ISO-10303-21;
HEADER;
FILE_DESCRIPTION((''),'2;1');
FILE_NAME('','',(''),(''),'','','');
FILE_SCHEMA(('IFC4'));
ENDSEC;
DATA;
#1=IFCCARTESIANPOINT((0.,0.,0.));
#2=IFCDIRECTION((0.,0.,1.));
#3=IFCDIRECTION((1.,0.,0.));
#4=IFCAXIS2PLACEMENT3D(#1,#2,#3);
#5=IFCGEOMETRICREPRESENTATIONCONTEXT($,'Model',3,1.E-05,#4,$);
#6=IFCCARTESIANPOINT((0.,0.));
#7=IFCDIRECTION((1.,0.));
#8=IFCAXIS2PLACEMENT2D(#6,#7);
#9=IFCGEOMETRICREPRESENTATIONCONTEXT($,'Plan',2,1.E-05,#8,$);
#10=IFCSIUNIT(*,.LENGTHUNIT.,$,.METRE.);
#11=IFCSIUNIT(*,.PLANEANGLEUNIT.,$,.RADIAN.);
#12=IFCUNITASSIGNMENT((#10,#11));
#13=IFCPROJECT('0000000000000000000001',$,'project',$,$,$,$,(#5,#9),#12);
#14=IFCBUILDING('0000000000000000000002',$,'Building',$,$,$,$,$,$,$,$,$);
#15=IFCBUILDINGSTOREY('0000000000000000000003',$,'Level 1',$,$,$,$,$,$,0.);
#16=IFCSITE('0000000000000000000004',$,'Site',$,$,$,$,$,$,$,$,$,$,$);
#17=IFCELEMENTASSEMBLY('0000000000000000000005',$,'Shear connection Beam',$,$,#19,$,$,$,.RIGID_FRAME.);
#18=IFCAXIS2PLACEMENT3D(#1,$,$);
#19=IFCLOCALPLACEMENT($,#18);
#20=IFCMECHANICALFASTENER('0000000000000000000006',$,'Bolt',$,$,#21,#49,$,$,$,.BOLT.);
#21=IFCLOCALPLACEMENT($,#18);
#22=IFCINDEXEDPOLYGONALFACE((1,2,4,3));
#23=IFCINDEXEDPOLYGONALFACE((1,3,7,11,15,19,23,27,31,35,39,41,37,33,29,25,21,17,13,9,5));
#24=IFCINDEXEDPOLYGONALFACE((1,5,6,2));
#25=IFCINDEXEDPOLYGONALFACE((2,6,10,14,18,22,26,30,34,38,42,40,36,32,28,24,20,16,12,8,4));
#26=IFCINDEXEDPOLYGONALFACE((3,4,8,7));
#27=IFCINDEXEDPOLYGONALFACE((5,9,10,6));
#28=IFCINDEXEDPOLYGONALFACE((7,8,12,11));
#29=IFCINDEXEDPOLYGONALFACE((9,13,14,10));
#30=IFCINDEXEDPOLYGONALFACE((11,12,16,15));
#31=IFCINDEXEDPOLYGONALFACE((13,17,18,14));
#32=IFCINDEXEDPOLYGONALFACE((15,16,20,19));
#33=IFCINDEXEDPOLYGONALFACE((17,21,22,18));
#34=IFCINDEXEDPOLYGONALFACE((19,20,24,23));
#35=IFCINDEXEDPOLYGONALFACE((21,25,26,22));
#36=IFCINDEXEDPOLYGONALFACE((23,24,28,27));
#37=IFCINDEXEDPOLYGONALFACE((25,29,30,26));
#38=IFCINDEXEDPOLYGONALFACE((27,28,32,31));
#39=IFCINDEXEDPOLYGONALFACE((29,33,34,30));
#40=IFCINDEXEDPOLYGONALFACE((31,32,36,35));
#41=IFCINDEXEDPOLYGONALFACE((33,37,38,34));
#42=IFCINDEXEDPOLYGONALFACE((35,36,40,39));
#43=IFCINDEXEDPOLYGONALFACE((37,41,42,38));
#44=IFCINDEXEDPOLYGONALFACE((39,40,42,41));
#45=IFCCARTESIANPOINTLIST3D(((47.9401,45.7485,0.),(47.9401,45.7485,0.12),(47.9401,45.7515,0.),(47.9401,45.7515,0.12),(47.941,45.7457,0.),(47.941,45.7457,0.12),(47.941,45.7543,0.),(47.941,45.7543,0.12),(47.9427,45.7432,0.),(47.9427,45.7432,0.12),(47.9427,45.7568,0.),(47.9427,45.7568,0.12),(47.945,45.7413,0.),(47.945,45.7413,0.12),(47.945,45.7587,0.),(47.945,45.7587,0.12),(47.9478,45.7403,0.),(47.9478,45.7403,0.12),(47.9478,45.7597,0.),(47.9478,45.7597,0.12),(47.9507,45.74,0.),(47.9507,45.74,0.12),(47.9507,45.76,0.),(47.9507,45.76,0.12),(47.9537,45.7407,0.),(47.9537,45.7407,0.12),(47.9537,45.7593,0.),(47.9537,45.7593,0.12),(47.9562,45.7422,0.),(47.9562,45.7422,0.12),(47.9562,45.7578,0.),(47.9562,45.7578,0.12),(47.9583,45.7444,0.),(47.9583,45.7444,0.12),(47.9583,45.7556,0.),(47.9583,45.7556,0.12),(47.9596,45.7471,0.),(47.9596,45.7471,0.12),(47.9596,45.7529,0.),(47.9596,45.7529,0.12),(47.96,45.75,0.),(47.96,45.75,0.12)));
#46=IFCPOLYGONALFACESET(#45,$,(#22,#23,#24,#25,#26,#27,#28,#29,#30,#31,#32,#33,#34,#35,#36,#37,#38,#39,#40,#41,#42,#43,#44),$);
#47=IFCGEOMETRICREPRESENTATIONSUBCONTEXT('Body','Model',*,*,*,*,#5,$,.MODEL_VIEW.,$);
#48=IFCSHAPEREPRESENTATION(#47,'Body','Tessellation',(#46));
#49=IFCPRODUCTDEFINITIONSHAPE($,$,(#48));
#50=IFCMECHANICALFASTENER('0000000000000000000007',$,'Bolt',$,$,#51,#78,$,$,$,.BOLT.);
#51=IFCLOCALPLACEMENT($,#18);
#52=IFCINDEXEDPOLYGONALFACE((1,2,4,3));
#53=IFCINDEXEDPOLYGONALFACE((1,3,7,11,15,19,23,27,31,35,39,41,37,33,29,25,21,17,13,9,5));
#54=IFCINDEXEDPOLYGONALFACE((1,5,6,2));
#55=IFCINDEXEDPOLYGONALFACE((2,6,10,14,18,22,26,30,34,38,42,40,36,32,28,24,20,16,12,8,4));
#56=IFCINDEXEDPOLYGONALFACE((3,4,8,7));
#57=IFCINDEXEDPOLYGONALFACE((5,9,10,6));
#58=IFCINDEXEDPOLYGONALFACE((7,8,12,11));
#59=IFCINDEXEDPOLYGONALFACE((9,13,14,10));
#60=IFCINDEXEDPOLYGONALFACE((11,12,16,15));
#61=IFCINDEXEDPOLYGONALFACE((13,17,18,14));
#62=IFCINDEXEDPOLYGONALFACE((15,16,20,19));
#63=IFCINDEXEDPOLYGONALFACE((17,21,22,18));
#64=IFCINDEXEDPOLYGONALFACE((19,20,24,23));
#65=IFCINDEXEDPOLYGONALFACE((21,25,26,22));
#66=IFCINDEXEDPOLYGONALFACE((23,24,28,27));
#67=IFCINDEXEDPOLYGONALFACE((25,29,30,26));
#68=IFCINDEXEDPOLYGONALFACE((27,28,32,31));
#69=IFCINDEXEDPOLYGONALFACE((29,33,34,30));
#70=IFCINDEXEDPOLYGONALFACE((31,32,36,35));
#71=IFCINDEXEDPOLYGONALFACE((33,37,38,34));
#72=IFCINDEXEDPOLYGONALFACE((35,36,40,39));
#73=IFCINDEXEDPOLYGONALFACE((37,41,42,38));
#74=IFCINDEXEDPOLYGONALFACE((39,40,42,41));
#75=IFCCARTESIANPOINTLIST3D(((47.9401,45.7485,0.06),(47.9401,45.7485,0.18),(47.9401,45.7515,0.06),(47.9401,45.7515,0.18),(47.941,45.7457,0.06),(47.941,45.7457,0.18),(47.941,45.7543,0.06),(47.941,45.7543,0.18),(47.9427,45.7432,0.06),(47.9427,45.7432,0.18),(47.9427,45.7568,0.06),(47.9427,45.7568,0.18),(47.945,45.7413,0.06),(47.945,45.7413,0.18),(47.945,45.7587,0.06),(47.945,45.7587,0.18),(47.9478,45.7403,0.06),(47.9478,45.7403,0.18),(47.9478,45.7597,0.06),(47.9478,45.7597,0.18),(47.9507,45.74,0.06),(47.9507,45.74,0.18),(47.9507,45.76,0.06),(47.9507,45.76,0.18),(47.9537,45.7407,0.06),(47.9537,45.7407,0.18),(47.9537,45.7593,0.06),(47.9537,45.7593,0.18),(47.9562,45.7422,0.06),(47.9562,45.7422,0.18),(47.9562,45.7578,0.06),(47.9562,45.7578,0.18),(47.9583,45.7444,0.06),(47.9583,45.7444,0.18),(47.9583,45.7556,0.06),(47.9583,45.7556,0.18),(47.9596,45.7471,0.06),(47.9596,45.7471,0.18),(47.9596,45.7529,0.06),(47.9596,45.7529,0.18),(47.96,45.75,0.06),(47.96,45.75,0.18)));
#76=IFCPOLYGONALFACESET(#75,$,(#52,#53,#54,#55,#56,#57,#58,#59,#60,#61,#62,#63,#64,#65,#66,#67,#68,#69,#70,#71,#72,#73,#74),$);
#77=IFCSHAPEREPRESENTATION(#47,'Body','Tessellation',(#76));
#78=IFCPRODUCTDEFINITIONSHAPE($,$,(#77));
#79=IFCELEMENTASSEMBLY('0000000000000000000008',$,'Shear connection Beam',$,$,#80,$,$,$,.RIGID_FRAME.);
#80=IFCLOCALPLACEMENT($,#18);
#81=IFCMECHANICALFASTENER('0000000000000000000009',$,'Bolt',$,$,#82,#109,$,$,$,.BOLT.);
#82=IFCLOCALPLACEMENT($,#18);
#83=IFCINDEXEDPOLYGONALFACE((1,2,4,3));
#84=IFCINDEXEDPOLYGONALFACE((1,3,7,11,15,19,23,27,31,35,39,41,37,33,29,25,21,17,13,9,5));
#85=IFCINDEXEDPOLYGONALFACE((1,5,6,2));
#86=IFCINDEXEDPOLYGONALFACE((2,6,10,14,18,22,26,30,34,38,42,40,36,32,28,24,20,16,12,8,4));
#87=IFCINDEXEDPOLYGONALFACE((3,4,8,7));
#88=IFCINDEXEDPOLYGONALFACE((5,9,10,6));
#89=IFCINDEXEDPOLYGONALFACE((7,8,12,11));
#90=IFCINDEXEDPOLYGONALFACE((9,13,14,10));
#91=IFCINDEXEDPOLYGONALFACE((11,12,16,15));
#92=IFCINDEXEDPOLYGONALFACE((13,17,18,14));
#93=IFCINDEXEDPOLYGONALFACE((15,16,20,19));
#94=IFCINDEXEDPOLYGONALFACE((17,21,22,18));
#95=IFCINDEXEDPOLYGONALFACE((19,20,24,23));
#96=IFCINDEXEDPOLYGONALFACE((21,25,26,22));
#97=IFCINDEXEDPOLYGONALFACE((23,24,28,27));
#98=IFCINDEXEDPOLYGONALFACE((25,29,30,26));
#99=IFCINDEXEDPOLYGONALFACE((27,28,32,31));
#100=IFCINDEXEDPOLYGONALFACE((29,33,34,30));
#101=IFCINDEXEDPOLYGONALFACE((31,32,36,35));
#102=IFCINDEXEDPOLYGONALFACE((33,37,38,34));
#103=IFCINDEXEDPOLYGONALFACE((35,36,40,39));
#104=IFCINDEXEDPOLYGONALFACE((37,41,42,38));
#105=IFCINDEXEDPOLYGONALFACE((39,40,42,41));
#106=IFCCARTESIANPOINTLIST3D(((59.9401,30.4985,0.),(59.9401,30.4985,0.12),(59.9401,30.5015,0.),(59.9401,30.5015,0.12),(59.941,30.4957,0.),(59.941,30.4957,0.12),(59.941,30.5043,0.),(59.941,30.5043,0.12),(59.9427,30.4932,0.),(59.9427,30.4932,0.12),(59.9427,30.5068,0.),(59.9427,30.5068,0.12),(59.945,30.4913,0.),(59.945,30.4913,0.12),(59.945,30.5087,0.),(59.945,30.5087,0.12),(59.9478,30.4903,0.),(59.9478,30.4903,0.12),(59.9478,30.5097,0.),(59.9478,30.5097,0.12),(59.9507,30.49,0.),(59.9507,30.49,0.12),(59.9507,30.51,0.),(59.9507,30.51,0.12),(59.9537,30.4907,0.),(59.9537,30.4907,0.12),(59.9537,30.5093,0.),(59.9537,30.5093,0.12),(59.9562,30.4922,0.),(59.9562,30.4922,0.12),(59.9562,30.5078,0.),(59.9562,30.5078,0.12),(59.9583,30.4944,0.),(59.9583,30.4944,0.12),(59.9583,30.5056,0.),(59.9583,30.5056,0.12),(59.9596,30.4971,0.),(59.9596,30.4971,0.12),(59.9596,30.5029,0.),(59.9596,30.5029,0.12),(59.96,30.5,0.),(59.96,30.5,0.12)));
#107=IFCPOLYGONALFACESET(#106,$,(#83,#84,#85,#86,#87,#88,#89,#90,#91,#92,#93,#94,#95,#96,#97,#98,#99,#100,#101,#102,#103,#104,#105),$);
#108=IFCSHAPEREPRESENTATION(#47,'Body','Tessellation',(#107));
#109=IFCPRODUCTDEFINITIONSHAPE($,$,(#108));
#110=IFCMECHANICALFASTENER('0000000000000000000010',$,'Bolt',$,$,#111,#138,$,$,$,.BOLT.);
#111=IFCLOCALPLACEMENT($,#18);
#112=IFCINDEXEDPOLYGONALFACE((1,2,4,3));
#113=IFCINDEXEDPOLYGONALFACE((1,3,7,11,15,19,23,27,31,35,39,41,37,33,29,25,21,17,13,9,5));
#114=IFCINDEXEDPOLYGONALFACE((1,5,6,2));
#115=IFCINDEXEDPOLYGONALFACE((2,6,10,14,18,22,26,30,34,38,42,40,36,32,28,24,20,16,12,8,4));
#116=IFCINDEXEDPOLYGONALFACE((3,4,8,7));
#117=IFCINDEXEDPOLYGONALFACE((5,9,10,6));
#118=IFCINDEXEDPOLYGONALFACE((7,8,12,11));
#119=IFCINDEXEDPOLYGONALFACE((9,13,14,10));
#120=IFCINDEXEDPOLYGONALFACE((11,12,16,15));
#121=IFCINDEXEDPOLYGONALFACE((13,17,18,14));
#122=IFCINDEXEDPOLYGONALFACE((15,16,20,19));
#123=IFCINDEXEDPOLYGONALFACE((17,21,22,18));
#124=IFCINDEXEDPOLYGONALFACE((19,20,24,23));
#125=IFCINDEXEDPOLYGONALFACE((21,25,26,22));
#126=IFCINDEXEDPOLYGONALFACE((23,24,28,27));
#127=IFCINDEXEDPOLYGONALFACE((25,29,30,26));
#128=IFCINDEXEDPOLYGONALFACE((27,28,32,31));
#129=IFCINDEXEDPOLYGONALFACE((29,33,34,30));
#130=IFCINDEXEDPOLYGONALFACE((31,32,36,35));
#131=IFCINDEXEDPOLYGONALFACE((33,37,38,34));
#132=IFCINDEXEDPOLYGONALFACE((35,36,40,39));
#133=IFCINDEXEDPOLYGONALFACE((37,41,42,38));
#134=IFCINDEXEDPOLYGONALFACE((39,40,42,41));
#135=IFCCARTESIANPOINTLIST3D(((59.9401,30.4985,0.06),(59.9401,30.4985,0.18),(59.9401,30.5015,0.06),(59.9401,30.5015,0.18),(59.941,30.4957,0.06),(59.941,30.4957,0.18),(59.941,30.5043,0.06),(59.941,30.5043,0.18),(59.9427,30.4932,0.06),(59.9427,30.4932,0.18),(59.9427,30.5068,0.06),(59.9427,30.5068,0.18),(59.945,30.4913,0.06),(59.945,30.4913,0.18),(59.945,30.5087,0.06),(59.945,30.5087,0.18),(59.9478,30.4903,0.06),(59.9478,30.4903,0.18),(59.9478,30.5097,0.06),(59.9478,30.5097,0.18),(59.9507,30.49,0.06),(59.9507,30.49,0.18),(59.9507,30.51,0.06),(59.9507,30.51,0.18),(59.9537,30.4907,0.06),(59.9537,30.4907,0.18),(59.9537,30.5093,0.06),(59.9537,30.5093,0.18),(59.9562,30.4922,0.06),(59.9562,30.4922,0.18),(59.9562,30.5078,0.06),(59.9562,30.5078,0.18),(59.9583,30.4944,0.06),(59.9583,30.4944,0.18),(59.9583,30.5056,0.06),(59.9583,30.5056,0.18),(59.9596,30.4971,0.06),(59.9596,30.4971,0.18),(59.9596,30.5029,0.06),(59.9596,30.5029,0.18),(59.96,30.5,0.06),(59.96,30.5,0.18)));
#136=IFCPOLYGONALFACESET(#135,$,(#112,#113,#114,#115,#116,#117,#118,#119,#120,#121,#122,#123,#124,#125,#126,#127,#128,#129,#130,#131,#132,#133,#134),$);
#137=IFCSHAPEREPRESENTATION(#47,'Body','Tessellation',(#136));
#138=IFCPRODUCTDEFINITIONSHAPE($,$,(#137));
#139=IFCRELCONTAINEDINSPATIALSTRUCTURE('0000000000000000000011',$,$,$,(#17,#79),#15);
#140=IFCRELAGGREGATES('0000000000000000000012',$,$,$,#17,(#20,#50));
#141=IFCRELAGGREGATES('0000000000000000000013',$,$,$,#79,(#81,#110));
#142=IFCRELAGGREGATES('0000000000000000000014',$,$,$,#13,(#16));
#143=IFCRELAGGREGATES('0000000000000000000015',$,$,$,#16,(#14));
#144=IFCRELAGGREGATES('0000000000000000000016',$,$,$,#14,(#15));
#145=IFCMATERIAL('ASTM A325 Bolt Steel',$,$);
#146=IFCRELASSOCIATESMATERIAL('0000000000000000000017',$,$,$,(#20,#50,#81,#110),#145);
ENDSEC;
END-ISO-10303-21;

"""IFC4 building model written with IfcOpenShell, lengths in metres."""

from ifc_helpers import new_model, si_unit, frame, origin_with_axes, origin_2d, origin_2d_with_axis, place, context, subcontext, project, spatial, circle, extrude, material, element, aggregate, save


model = new_model("IFC4")

# Units and contexts
model_context = context("Model", 3, precision=1e-05, world=origin_with_axes())
plan_context = context("Plan", 2, precision=1e-05, world=origin_2d_with_axis())
body_context = subcontext(model_context, "Body", "Model", "MODEL_VIEW")
ifc_project = project(units=[si_unit("LENGTHUNIT", "METRE"), si_unit("PLANEANGLEUNIT", "RADIAN")], contexts=[model_context, plan_context])

# Site, building, storey
site = spatial("IfcSite", under=ifc_project, Name="Site")
building = spatial("IfcBuilding", under=site, Name="Building")
storey = spatial("IfcBuildingStorey", under=building, Name="Level 1", Elevation=0.0)

# Element assembly
assembly_1 = element("IfcElementAssembly", 1, inside=storey, Name="Shear connection Beam", PredefinedType="RIGID_FRAME")

# Shared definitions
ifc_material_1 = material(Name="ASTM A325 Bolt Steel")

# Mechanical fasteners
mechanical_fastener_1_placement = place(None, frame((47.95, 45.75, 0.0), z_axis=(0.0, 0.0, 1.0), x_axis=(1.0, 0.0, 0.0)))
mechanical_fastener_1 = element("IfcMechanicalFastener", 2, at=mechanical_fastener_1_placement, material=ifc_material_1, Name="Bolt", PredefinedType="BOLT", context=body_context, shape_type="SweptSolid", body=[
    extrude(circle(Radius=0.01, at=origin_2d()), origin_with_axes(), (0.0, 0.0, 1.0), 0.12),
])
mechanical_fastener_2_placement = place(None, frame((47.95, 45.75, 0.06), z_axis=(0.0, 0.0, 1.0), x_axis=(1.0, 0.0, 0.0)))
mechanical_fastener_2 = element("IfcMechanicalFastener", 3, at=mechanical_fastener_2_placement, material=ifc_material_1, Name="Bolt", PredefinedType="BOLT", context=body_context, shape_type="SweptSolid", body=[
    extrude(circle(Radius=0.01, at=origin_2d()), origin_with_axes(), (0.0, 0.0, 1.0), 0.12),
])
aggregate(assembly_1, [mechanical_fastener_1, mechanical_fastener_2])

# Element assembly, mechanical fasteners
assembly_2 = element("IfcElementAssembly", 4, inside=storey, Name="Shear connection Beam", PredefinedType="RIGID_FRAME")
mechanical_fastener_3_placement = place(None, frame((59.95, 30.5, 0.0), z_axis=(0.0, 0.0, 1.0), x_axis=(1.0, 0.0, 0.0)))
mechanical_fastener_3 = element("IfcMechanicalFastener", 5, at=mechanical_fastener_3_placement, material=ifc_material_1, Name="Bolt", PredefinedType="BOLT", context=body_context, shape_type="SweptSolid", body=[
    extrude(circle(Radius=0.01, at=origin_2d()), origin_with_axes(), (0.0, 0.0, 1.0), 0.12),
])
mechanical_fastener_4_placement = place(None, frame((59.95, 30.5, 0.06), z_axis=(0.0, 0.0, 1.0), x_axis=(1.0, 0.0, 0.0)))
mechanical_fastener_4 = element("IfcMechanicalFastener", 6, at=mechanical_fastener_4_placement, material=ifc_material_1, Name="Bolt", PredefinedType="BOLT", context=body_context, shape_type="SweptSolid", body=[
    extrude(circle(Radius=0.01, at=origin_2d()), origin_with_axes(), (0.0, 0.0, 1.0), 0.12),
])
aggregate(assembly_2, [mechanical_fastener_3, mechanical_fastener_4])

save(model, "model.ifc")
